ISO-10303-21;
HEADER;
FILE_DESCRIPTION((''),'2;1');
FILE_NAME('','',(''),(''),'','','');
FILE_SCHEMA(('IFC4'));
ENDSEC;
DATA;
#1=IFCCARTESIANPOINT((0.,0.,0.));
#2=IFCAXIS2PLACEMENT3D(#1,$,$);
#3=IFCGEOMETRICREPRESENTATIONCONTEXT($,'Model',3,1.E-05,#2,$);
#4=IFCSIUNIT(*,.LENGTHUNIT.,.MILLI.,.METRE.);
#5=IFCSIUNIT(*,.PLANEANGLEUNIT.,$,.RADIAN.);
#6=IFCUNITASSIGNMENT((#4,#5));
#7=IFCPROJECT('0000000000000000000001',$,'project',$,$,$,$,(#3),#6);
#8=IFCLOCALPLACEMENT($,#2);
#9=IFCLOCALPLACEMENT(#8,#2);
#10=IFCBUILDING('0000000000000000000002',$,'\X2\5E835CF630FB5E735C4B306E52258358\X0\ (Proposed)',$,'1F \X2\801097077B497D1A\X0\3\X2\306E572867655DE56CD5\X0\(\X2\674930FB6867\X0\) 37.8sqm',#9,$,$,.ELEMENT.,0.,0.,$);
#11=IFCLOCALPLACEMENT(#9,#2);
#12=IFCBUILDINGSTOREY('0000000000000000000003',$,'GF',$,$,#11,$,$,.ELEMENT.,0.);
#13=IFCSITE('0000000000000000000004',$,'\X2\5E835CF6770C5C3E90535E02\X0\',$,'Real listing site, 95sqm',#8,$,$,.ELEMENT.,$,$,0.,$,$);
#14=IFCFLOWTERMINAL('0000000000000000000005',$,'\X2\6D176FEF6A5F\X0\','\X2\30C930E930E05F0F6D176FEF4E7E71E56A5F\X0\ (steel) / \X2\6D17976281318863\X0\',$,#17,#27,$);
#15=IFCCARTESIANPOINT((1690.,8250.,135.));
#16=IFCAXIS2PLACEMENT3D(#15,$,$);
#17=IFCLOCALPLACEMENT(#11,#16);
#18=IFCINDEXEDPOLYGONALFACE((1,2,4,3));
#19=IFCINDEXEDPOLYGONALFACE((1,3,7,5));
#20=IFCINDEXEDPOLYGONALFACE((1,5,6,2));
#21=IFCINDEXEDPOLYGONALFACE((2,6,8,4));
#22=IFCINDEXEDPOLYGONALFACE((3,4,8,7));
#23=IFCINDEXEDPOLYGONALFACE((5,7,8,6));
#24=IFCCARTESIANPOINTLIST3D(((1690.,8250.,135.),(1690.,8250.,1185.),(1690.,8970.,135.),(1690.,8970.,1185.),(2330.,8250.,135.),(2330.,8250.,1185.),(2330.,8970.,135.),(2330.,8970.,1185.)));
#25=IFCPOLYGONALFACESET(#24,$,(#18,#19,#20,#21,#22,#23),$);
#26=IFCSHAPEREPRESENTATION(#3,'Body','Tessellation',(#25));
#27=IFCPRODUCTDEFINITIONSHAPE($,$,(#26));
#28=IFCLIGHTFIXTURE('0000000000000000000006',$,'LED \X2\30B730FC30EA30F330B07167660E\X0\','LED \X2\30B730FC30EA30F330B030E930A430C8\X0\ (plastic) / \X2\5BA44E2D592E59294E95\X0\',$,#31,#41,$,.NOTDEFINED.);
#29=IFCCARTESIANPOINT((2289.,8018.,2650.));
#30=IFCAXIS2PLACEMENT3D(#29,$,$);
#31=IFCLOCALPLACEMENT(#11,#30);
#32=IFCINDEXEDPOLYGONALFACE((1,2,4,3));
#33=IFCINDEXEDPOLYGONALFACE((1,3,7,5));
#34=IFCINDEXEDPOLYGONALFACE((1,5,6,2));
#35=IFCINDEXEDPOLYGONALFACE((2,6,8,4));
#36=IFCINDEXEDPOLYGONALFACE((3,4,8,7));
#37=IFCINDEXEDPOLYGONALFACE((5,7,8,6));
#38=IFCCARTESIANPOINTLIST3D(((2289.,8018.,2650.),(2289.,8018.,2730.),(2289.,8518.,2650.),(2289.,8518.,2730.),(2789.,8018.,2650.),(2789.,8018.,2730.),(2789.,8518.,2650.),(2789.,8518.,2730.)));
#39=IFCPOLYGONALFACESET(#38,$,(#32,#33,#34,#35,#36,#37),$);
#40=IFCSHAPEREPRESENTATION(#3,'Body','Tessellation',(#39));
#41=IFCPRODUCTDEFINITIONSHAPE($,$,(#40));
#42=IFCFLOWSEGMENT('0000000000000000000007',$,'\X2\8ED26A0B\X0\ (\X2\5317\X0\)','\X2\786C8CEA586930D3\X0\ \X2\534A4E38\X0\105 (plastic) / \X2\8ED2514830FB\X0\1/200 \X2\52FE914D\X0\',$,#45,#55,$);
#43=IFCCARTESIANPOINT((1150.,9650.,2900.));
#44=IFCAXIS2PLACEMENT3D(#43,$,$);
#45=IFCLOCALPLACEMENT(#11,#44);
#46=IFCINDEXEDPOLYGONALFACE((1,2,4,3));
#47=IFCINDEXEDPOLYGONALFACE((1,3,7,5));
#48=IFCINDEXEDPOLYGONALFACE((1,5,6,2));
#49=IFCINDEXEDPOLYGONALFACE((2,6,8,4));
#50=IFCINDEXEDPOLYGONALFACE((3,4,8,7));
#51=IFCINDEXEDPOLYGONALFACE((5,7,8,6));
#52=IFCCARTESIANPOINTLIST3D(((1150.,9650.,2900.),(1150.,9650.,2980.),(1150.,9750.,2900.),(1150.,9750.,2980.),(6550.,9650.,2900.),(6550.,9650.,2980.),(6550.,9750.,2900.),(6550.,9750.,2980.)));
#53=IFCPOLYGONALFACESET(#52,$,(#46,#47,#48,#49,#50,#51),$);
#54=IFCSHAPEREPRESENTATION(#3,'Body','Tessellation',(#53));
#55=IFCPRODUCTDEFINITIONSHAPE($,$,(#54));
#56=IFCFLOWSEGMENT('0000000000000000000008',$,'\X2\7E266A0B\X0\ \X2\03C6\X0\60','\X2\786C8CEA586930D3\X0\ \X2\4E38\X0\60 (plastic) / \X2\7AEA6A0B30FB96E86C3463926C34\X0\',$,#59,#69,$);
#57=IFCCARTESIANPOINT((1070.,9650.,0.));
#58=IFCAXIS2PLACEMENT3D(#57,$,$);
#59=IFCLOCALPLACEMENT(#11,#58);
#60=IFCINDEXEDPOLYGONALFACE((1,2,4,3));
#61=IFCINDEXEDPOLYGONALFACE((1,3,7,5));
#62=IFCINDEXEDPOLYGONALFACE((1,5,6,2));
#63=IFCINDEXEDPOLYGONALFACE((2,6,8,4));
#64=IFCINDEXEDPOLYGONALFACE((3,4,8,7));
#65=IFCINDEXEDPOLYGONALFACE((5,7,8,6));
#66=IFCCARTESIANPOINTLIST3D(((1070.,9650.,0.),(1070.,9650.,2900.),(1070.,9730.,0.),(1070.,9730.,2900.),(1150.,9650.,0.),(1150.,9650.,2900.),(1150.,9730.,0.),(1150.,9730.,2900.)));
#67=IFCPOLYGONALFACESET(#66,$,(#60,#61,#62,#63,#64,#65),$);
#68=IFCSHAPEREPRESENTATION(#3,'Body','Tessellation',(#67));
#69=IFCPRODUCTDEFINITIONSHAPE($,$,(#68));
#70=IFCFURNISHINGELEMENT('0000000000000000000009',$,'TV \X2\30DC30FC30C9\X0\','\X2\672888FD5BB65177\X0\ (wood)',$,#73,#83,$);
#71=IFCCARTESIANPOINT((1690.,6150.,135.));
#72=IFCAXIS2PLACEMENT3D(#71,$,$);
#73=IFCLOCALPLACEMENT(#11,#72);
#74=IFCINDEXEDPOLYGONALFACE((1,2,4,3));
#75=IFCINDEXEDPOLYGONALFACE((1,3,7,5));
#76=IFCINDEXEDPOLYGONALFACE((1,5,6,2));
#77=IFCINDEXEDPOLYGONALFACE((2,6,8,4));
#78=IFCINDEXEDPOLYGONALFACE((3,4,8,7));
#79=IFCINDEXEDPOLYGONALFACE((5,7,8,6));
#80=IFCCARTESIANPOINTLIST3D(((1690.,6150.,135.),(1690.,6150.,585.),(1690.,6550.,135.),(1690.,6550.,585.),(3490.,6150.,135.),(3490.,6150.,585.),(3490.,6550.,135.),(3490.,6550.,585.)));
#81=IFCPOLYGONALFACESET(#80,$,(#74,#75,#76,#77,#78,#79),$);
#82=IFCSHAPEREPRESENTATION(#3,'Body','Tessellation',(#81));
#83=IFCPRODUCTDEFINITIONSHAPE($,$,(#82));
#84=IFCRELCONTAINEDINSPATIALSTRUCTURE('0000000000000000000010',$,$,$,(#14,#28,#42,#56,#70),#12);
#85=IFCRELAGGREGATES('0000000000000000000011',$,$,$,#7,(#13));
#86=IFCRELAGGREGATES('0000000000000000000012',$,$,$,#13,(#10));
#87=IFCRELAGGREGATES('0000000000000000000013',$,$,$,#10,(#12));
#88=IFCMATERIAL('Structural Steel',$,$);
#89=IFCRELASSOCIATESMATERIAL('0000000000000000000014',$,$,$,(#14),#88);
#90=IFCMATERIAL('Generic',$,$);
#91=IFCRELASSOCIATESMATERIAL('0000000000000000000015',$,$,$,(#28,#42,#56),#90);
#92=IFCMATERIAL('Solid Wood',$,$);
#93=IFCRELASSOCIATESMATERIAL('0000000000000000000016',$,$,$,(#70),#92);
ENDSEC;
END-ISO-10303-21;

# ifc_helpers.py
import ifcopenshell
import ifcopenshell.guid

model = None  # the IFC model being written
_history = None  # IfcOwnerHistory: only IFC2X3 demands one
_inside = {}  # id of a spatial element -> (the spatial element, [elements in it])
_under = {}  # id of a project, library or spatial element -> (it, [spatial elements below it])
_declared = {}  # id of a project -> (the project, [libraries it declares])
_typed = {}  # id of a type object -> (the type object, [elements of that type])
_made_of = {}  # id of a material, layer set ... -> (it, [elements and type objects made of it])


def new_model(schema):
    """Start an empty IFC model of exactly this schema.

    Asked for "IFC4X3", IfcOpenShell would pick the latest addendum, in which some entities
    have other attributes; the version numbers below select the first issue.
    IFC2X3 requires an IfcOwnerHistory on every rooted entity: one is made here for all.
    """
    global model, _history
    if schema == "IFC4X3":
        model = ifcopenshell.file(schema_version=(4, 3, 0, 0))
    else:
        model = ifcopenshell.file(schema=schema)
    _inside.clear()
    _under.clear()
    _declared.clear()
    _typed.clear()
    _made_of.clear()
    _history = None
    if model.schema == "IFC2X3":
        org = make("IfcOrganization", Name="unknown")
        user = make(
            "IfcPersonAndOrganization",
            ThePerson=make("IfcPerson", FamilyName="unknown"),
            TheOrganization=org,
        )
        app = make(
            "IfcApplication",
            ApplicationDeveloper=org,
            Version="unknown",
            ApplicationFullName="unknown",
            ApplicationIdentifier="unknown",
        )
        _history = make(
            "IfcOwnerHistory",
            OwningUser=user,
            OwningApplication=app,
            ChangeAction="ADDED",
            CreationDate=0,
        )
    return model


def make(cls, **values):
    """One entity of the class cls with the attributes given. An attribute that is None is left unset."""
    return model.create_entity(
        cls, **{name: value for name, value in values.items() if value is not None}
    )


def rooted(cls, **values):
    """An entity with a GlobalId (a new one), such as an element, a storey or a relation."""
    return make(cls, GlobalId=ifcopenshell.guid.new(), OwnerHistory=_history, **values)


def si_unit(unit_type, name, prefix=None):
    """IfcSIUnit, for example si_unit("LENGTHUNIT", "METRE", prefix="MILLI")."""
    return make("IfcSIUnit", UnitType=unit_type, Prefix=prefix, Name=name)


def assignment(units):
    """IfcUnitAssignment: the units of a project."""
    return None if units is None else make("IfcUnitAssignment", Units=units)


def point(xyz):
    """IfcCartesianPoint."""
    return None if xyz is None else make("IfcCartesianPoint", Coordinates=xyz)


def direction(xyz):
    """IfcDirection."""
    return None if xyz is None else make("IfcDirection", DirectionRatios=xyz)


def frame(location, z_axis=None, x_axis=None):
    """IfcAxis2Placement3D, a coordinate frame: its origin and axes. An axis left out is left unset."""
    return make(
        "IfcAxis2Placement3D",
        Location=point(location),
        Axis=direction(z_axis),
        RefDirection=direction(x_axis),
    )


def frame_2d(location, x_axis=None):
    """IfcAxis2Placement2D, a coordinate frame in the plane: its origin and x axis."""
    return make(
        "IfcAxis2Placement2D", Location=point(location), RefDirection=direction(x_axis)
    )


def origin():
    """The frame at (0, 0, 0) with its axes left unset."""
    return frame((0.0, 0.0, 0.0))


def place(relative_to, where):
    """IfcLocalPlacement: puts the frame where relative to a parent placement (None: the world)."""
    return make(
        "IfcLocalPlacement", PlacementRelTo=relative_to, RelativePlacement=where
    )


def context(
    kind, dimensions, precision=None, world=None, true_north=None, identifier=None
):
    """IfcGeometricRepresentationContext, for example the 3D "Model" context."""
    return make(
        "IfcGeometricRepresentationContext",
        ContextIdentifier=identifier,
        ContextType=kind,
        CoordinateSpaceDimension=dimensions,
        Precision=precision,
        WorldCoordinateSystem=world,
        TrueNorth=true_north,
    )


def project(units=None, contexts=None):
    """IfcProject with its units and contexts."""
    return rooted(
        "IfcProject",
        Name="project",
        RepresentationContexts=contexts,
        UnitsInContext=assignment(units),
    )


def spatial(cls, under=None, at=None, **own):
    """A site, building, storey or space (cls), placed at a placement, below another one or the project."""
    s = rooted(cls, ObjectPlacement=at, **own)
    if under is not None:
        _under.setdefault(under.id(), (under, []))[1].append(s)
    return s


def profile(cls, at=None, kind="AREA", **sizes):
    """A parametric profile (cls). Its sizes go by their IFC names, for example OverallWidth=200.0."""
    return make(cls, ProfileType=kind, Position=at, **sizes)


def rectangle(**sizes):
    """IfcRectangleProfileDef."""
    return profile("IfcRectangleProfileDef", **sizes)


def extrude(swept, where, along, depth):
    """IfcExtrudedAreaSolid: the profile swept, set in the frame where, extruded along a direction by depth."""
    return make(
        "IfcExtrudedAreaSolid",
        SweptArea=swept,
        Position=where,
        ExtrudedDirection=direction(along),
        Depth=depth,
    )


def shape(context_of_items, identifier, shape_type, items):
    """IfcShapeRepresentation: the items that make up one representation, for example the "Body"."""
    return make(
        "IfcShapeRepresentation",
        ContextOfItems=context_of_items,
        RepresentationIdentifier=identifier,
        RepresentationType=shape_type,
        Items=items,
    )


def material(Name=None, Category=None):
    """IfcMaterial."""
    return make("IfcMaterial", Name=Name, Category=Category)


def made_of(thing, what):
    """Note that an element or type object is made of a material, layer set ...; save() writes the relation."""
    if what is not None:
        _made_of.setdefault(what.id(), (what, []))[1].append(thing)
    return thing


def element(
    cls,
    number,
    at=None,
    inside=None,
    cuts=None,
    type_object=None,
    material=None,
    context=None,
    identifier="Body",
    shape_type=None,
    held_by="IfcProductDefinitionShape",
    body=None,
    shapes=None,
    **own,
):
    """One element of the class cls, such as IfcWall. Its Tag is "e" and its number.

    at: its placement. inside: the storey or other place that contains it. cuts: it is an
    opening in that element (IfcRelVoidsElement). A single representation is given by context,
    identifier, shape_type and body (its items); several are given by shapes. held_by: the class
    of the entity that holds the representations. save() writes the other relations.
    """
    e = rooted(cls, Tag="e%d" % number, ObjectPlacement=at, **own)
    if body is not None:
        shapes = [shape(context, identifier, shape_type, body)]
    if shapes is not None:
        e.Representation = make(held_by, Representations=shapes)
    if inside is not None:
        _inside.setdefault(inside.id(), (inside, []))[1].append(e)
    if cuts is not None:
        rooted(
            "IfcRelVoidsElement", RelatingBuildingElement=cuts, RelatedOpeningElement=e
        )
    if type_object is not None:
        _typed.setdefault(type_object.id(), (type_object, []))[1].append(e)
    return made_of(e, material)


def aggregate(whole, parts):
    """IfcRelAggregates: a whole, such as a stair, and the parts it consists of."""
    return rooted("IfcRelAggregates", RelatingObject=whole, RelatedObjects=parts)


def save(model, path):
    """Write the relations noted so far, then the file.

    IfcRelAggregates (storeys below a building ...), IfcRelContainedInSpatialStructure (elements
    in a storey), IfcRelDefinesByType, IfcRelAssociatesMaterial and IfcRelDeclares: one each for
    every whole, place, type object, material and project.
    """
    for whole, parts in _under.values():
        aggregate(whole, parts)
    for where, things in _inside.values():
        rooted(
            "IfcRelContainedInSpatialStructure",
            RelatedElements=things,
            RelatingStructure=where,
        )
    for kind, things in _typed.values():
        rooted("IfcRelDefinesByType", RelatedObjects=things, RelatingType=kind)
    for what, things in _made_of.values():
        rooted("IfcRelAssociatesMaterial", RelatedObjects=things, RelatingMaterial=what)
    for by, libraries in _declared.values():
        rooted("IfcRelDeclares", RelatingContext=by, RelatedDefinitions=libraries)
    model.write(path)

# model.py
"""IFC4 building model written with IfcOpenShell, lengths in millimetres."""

from ifc_helpers import new_model, si_unit, frame, frame_2d, origin, place, context, project, spatial, rectangle, extrude, material, element, save


model = new_model("IFC4")

# Units and contexts
model_context = context("Model", 3, precision=1e-05, world=origin())
ifc_project = project(units=[si_unit("LENGTHUNIT", "METRE", prefix="MILLI"), si_unit("PLANEANGLEUNIT", "RADIAN")], contexts=[model_context])

# Site, building, storey
site_placement = place(None, origin())
site = spatial("IfcSite", under=ifc_project, at=site_placement, Name="広島県尾道市", ObjectType="Real listing site, 95sqm", CompositionType="ELEMENT", RefElevation=0.0)
building_placement = place(site_placement, origin())
building = spatial("IfcBuilding", under=site, at=building_placement, Name="広島・平屋の別荘 (Proposed)", ObjectType="1F 耐震等級3の在来工法(杉・桧) 37.8sqm", CompositionType="ELEMENT", ElevationOfRefHeight=0.0, ElevationOfTerrain=0.0)
storey_placement = place(building_placement, origin())
storey = spatial("IfcBuildingStorey", under=building, at=storey_placement, Name="GF", CompositionType="ELEMENT", Elevation=0.0)

# Shared definitions
ifc_material_1 = material(Name="Solid Wood")

# Shared definitions
ifc_material_2 = material(Name="Generic")

# Shared definitions
ifc_material_3 = material(Name="Structural Steel")

# Flow terminal
flow_terminal_placement = place(storey_placement, frame((1690.0, 8250.0, 135.0)))
element("IfcFlowTerminal", 1, at=flow_terminal_placement, inside=storey, material=ifc_material_3, Name="洗濯機", Description="ドラム式洗濯乾燥機 (steel) / 洗面脱衣", context=model_context, shape_type="SweptSolid", body=[
    extrude(rectangle(XDim=640.0, YDim=720.0, at=frame_2d((320.0, 360.0))), frame((1690.0, 8250.0, 135.0)), (0.0, 0.0, 1.0), 1050.0),
])

# Light fixture
light_fixture_placement = place(storey_placement, frame((2289.0, 8018.0, 2650.0)))
element("IfcLightFixture", 2, at=light_fixture_placement, inside=storey, material=ifc_material_2, Name="LED シーリング照明", Description="LED シーリングライト (plastic) / 室中央天井", PredefinedType="NOTDEFINED", context=model_context, shape_type="SweptSolid", body=[
    extrude(rectangle(XDim=500.0, YDim=500.0, at=frame_2d((250.0, 250.0))), frame((2289.0, 8018.0, 2650.0)), (0.0, 0.0, 1.0), 80.0),
])

# Flow segments
flow_segment_1_placement = place(storey_placement, frame((1150.0, 9650.0, 2900.0)))
element("IfcFlowSegment", 3, at=flow_segment_1_placement, inside=storey, material=ifc_material_2, Name="軒樋 (北)", Description="硬質塩ビ 半丸105 (plastic) / 軒先・1/200 勾配", context=model_context, shape_type="SweptSolid", body=[
    extrude(rectangle(XDim=5400.0, YDim=100.0, at=frame_2d((2700.0, 50.0))), frame((1150.0, 9650.0, 2900.0)), (0.0, 0.0, 1.0), 80.0),
])
flow_segment_2_placement = place(storey_placement, frame((1070.0, 9650.0, 0.0)))
element("IfcFlowSegment", 4, at=flow_segment_2_placement, inside=storey, material=ifc_material_2, Name="縦樋 φ60", Description="硬質塩ビ 丸60 (plastic) / 竪樋・雨水排水", context=model_context, shape_type="SweptSolid", body=[
    extrude(rectangle(XDim=80.0, YDim=80.0, at=frame_2d((40.0, 40.0))), frame((1070.0, 9650.0, 0.0)), (0.0, 0.0, 1.0), 2900.0),
])

# Furnishing element
furnishing_placement = place(storey_placement, frame((1690.0, 6150.0, 135.0)))
element("IfcFurnishingElement", 5, at=furnishing_placement, inside=storey, material=ifc_material_1, Name="TV ボード", Description="木製家具 (wood)", context=model_context, shape_type="SweptSolid", body=[
    extrude(rectangle(XDim=1800.0, YDim=400.0, at=frame_2d((900.0, 200.0))), frame((1690.0, 6150.0, 135.0)), (0.0, 0.0, 1.0), 450.0),
])

save(model, "model.ifc")
